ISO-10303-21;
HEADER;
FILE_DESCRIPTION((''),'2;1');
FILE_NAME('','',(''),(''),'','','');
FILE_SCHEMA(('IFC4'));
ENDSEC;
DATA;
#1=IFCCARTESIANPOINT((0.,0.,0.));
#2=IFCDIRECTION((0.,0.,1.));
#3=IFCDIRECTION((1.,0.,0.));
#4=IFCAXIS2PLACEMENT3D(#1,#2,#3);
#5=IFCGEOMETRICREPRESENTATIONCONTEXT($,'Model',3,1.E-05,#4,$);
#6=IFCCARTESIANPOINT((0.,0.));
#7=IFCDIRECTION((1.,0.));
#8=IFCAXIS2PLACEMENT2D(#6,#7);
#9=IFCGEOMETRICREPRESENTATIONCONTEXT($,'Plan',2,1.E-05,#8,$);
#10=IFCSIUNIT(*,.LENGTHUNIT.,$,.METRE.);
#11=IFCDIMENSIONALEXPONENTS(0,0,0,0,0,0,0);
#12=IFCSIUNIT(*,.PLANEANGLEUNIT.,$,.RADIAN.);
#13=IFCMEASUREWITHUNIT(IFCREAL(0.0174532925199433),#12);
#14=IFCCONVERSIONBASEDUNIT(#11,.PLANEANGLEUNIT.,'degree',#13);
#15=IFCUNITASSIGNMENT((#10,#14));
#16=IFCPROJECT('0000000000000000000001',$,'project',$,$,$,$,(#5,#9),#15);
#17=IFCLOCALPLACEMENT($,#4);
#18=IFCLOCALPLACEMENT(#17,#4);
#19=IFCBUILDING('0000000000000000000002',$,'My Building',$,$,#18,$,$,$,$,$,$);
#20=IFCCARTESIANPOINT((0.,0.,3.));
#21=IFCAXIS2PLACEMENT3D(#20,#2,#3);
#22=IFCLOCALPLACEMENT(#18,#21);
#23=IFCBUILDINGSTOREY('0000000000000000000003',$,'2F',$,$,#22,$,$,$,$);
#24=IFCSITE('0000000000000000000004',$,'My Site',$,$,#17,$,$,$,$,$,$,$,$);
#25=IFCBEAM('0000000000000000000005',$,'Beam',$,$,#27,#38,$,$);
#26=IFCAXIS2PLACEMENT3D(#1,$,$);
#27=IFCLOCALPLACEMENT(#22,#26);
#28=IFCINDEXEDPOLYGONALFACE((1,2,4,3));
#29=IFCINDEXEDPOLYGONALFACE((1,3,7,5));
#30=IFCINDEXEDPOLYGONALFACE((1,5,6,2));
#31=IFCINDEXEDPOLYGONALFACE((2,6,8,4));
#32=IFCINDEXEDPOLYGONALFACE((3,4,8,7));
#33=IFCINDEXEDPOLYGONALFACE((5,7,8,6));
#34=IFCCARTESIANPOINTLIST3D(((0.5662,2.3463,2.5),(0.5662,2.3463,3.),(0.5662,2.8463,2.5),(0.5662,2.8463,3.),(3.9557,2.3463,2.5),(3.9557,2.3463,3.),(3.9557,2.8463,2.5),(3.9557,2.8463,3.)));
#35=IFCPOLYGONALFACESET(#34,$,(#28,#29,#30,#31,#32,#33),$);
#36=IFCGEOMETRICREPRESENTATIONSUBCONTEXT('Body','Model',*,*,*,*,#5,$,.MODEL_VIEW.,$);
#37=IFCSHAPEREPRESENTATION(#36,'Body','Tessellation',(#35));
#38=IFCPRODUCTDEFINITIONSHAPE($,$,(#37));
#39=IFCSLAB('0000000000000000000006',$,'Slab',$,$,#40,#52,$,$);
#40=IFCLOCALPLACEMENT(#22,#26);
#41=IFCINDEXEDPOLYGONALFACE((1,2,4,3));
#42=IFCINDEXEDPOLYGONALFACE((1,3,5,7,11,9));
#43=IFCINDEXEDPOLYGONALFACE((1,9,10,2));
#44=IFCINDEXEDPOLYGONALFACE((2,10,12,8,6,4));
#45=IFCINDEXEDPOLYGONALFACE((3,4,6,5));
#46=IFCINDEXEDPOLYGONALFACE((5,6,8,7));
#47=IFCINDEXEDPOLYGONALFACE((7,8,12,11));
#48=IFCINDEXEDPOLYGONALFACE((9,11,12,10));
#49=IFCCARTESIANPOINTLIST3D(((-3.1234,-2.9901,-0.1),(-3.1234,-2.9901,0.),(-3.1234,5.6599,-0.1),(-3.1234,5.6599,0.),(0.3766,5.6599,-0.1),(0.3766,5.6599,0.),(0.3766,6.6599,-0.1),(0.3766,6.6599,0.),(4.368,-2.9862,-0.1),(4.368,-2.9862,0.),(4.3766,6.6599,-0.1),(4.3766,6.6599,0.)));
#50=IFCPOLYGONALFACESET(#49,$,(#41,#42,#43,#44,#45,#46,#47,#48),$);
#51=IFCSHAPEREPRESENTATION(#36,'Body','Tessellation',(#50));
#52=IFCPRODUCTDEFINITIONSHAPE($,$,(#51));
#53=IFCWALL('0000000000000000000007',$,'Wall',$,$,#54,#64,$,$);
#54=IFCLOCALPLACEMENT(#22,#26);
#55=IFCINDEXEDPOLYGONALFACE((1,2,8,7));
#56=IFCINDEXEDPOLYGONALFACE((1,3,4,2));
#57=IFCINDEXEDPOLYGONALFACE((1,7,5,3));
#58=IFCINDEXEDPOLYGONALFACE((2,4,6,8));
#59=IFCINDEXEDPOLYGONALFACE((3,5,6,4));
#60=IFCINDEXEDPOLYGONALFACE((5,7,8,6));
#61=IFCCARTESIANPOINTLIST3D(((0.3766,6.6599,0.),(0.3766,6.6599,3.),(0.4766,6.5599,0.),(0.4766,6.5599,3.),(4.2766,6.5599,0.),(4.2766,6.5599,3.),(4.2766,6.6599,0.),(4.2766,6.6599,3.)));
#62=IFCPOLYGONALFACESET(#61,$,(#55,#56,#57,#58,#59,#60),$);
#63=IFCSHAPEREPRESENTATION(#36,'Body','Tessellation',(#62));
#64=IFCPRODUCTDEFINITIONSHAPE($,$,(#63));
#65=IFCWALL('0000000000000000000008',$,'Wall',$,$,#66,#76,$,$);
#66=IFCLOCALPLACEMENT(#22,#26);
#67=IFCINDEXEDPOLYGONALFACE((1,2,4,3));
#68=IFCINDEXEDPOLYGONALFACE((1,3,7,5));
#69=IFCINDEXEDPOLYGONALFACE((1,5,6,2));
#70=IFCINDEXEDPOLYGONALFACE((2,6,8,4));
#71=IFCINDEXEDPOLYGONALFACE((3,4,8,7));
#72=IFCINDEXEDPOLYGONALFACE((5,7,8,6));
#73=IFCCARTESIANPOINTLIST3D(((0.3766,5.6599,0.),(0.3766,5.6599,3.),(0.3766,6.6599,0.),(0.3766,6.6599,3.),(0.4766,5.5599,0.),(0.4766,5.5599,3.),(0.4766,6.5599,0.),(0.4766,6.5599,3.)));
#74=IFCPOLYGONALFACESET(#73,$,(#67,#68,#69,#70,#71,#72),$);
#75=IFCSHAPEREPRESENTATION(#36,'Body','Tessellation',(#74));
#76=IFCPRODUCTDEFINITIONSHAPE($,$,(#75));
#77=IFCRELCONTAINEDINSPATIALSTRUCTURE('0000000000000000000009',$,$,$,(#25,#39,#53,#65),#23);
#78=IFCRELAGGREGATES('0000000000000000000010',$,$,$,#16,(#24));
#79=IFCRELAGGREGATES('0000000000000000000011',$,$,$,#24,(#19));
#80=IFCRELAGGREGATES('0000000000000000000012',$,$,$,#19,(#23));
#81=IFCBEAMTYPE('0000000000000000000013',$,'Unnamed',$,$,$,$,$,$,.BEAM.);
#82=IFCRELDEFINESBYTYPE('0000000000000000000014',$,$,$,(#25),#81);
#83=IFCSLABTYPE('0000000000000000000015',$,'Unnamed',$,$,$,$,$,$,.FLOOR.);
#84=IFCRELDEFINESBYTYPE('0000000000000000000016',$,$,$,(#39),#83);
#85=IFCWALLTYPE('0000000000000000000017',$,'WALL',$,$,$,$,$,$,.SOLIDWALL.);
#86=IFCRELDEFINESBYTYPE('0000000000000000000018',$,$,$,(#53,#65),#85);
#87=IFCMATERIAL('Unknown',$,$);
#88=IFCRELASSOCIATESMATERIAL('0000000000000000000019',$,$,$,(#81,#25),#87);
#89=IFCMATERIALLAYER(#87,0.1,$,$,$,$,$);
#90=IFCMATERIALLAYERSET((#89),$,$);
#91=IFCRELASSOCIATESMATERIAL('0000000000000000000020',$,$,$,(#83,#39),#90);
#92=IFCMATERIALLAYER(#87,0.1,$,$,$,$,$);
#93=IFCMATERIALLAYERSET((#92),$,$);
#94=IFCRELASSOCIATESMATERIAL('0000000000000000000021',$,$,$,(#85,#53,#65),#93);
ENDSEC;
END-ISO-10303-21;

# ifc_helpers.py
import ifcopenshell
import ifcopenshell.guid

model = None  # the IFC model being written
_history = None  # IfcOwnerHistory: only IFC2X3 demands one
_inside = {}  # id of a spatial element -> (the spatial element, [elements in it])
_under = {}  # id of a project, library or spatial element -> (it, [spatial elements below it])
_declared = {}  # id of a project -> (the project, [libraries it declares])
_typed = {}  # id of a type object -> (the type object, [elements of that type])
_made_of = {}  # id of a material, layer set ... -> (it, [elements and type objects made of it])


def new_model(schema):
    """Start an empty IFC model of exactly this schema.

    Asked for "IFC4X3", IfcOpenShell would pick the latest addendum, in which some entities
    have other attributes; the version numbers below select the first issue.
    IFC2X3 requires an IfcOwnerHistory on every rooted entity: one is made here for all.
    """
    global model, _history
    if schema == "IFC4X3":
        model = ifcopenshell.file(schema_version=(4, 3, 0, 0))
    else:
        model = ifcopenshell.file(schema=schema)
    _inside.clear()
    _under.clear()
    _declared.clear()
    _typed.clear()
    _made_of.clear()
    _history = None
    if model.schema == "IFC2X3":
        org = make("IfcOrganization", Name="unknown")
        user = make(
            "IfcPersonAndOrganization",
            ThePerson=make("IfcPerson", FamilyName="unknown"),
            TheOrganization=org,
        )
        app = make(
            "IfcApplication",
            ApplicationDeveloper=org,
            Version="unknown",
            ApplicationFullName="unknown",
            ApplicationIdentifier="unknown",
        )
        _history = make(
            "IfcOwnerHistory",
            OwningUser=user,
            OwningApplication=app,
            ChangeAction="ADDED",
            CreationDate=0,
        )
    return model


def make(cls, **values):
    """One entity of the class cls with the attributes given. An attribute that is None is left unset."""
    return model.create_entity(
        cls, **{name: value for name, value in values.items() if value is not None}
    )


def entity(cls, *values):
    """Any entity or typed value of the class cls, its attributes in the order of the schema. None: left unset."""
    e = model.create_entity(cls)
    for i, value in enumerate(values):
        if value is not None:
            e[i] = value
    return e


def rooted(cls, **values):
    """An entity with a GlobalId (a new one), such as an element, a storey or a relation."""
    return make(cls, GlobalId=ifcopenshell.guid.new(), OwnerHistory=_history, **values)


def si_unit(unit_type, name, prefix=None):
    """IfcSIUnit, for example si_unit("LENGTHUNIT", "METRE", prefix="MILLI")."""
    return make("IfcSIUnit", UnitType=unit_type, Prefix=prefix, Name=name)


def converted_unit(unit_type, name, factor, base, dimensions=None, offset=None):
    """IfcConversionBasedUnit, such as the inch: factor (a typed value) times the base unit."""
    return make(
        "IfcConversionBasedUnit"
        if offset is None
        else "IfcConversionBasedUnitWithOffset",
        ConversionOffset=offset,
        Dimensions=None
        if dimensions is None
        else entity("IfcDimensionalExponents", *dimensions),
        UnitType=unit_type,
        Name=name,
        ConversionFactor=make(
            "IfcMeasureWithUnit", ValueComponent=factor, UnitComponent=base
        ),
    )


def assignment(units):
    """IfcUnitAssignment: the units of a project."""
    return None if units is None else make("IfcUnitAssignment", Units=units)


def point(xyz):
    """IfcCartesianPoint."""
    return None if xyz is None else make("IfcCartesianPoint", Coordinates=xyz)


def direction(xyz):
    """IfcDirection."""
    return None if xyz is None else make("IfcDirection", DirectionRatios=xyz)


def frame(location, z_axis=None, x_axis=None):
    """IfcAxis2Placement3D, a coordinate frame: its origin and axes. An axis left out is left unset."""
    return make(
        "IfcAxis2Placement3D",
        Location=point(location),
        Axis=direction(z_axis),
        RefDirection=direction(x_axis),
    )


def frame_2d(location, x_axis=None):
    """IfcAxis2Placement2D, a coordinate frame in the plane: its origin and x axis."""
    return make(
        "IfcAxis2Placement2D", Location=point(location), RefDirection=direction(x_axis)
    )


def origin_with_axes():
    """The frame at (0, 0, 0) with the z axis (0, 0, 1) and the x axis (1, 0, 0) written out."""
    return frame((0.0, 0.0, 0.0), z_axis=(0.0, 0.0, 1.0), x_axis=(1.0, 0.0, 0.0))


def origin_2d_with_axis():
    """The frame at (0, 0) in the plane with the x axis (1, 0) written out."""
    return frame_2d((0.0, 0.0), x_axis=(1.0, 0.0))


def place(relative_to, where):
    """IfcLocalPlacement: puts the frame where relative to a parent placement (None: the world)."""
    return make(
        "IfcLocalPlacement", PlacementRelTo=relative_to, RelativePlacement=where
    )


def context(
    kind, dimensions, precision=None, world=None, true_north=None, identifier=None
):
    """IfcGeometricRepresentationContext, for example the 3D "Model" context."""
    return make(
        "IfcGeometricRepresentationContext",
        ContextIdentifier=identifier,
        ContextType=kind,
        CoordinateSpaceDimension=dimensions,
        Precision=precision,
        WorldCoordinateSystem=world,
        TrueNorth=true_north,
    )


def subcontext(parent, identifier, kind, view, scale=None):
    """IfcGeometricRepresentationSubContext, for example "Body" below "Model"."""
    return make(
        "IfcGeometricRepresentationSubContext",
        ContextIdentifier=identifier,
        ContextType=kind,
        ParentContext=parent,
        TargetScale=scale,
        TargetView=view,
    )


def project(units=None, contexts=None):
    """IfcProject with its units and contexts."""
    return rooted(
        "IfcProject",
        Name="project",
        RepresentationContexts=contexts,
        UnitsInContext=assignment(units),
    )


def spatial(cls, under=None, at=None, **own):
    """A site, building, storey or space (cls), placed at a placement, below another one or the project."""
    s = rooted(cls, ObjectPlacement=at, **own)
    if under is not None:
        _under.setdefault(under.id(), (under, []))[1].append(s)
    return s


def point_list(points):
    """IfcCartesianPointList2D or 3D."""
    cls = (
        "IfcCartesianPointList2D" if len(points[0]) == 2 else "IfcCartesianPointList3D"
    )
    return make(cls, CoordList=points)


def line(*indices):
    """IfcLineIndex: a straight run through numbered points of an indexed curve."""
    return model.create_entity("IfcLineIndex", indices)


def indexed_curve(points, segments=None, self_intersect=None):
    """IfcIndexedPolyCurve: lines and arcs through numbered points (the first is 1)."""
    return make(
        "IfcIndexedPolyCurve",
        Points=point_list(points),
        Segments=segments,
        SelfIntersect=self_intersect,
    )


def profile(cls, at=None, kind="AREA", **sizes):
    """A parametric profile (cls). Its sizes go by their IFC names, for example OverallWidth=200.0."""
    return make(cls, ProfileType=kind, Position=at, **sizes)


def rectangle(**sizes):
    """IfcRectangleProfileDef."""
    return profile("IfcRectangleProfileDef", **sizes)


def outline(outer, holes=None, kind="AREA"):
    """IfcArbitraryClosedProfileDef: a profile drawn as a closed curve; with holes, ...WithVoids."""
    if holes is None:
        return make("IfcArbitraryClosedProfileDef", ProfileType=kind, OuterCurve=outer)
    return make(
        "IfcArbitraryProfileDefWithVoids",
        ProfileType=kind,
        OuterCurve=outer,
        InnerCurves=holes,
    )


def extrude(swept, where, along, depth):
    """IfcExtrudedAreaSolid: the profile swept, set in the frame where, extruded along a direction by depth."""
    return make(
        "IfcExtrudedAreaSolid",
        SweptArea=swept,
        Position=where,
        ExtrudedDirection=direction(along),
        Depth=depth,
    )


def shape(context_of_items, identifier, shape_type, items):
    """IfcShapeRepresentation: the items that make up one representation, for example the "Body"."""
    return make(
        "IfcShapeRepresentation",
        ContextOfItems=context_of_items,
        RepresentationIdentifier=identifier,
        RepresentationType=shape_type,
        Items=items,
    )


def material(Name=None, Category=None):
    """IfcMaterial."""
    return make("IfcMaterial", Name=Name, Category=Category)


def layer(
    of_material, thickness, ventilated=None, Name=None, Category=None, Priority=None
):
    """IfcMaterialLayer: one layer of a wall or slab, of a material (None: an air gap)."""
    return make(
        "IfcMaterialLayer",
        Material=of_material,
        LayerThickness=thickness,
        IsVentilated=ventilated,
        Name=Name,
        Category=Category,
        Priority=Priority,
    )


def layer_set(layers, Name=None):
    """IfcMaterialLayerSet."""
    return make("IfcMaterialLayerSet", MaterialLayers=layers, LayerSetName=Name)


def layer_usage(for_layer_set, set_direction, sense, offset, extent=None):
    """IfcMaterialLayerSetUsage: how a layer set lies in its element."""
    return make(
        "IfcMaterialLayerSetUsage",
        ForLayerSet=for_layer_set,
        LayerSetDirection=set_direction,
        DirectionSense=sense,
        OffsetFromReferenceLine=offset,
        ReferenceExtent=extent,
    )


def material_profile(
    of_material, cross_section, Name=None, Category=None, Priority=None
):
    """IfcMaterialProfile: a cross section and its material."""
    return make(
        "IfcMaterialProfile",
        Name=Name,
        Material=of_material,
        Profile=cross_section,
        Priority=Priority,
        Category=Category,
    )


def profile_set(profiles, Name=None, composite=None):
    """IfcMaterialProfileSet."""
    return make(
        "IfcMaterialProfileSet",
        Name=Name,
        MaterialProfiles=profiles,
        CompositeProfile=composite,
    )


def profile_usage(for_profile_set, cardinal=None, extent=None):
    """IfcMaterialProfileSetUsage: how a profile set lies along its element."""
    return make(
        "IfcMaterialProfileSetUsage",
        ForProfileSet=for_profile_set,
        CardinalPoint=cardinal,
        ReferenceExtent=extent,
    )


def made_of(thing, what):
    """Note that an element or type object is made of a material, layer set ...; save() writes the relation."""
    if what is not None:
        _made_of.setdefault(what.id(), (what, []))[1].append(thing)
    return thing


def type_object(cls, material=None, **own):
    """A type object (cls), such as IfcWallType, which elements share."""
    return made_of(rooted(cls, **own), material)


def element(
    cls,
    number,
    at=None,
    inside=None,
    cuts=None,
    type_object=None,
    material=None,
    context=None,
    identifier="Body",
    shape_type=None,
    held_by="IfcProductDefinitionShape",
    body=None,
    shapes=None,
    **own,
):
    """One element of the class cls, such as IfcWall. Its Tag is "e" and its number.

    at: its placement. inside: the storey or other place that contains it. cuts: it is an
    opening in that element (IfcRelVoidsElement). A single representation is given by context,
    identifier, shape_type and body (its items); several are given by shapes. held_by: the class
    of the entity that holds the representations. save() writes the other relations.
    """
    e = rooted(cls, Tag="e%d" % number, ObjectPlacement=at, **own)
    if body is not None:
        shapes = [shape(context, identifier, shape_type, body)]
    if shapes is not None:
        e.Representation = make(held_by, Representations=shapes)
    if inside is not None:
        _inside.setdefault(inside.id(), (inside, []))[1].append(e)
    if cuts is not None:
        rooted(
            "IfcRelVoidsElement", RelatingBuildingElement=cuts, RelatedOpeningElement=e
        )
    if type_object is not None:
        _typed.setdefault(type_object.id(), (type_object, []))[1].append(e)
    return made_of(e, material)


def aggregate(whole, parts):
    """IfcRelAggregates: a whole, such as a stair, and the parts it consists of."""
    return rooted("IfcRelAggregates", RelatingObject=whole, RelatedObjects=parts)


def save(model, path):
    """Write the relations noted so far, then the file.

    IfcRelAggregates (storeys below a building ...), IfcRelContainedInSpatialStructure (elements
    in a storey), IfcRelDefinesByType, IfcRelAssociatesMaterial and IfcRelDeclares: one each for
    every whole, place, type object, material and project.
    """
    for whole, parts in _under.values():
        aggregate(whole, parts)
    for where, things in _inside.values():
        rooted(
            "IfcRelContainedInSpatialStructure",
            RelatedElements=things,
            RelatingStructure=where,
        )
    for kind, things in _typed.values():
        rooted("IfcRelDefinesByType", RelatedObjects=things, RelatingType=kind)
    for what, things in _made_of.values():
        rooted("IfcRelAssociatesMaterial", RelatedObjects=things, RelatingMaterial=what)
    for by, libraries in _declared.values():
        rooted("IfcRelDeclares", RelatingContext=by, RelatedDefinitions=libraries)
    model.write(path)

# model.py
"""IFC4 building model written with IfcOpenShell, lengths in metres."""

from ifc_helpers import new_model, entity, si_unit, converted_unit, frame, origin_with_axes, origin_2d_with_axis, place, context, subcontext, project, spatial, line, indexed_curve, rectangle, outline, extrude, material, layer, layer_set, layer_usage, material_profile, profile_set, profile_usage, type_object, element, save


model = new_model("IFC4")

# Units and contexts
model_context = context("Model", 3, precision=1e-05, world=origin_with_axes())
plan_context = context("Plan", 2, precision=1e-05, world=origin_2d_with_axis())
body_context_1 = subcontext(model_context, "Body", "Model", "MODEL_VIEW")
ifc_project = project(units=[si_unit("LENGTHUNIT", "METRE"), converted_unit("PLANEANGLEUNIT", "degree", entity("IfcReal", 0.0174532925199433), si_unit("PLANEANGLEUNIT", "RADIAN"), dimensions=[0, 0, 0, 0, 0, 0, 0])], contexts=[model_context, plan_context])

# Site, building, storey
site_placement = place(None, origin_with_axes())
site = spatial("IfcSite", under=ifc_project, at=site_placement, Name="My Site")
building_placement = place(site_placement, origin_with_axes())
building = spatial("IfcBuilding", under=site, at=building_placement, Name="My Building")
storey_placement = place(building_placement, frame((0.0, 0.0, 3.0), z_axis=(0.0, 0.0, 1.0), x_axis=(1.0, 0.0, 0.0)))
storey = spatial("IfcBuildingStorey", under=building, at=storey_placement, Name="2F")

# Shared definitions
ifc_material = material(Name="Unknown")

# Beam
ifc_material_profile_1 = material_profile(ifc_material, rectangle(XDim=0.5, YDim=0.5))
ifc_profile_set_1 = profile_set([ifc_material_profile_1])
beam_type = type_object("IfcBeamType", Name="Unnamed", PredefinedType="BEAM", material=ifc_profile_set_1)
ifc_profile_usage_1 = profile_usage(ifc_profile_set_1, cardinal=7)
beam_1_placement = place(storey_placement, frame((3.9557, 2.3463, 3.0), z_axis=(-1.0, 0.0, 0.0), x_axis=(0.0, -1.0, 0.0)))
element("IfcBeam", 1, at=beam_1_placement, inside=storey, type_object=beam_type, material=ifc_profile_usage_1, Name="Beam", context=body_context_1, shape_type="SweptSolid", body=[
    extrude(rectangle(XDim=0.5, YDim=0.5), frame((-0.25, -0.25, 0.0), z_axis=(0.0, 0.0, 1.0), x_axis=(1.0, 0.0, 0.0)), (0.0, 0.0, 1.0), 3.3895),
])

# Slab
ifc_layer_1 = layer(ifc_material, 0.1)
ifc_layer_set_1 = layer_set([ifc_layer_1])
ifc_layer_usage_1 = layer_usage(ifc_layer_set_1, "AXIS3", "POSITIVE", -0.1)
slab_type = type_object("IfcSlabType", Name="Unnamed", PredefinedType="FLOOR", material=ifc_layer_set_1)
slab_placement = place(storey_placement, frame((4.3766, 6.6599, 0.0), z_axis=(0.0, 0.0, 1.0), x_axis=(1.0, 0.0, 0.0)))
element("IfcSlab", 2, at=slab_placement, inside=storey, type_object=slab_type, material=ifc_layer_usage_1, Name="Slab", context=body_context_1, shape_type="SweptSolid", body=[
    extrude(outline(indexed_curve([(0.0, 0.0), (-4.0, 0.0), (-4.0, -1.0), (-7.5, -1.0), (-7.5, -9.65), (-0.0086, -9.6461), (0.0, 0.0)])), frame((0.0, 0.0, -0.1), z_axis=(0.0, 0.0, 1.0), x_axis=(1.0, 0.0, 0.0)), (0.0, 0.0, 1.0), 0.1),
])

# Walls
ifc_layer_2 = layer(ifc_material, 0.1)
ifc_layer_set_2 = layer_set([ifc_layer_2])
ifc_layer_usage_2 = layer_usage(ifc_layer_set_2, "AXIS2", "POSITIVE", 0.0)
wall_type = type_object("IfcWallType", Name="WALL", PredefinedType="SOLIDWALL", material=ifc_layer_set_2)
wall_1_placement = place(storey_placement, frame((4.2766, 6.6599, 0.0), z_axis=(0.0, 0.0, 1.0), x_axis=(-1.0, 0.0, 0.0)))
element("IfcWall", 3, at=wall_1_placement, inside=storey, type_object=wall_type, material=ifc_layer_usage_2, Name="Wall", context=body_context_1, shape_type="SweptSolid", body=[
    extrude(outline(indexed_curve([(0.0, 0.0), (0.0, 0.1), (3.8, 0.1), (3.9, 0.0)], segments=[line(1, 2, 3, 4, 1)])), origin_with_axes(), (0.0, 0.0, 1.0), 3.0),
])
ifc_layer_usage_3 = layer_usage(ifc_layer_set_2, "AXIS2", "POSITIVE", 0.0)
wall_2_placement = place(storey_placement, frame((0.3766, 6.6599, 0.0), z_axis=(0.0, 0.0, 1.0), x_axis=(0.0, -1.0, 0.0)))
element("IfcWall", 4, at=wall_2_placement, inside=storey, type_object=wall_type, material=ifc_layer_usage_3, Name="Wall", context=body_context_1, shape_type="SweptSolid", body=[
    extrude(outline(indexed_curve([(0.0, 0.0), (0.1, 0.1), (1.1, 0.1), (1.0, 0.0)], segments=[line(1, 2, 3, 4, 1)])), origin_with_axes(), (0.0, 0.0, 1.0), 3.0),
])

save(model, "model.ifc")
